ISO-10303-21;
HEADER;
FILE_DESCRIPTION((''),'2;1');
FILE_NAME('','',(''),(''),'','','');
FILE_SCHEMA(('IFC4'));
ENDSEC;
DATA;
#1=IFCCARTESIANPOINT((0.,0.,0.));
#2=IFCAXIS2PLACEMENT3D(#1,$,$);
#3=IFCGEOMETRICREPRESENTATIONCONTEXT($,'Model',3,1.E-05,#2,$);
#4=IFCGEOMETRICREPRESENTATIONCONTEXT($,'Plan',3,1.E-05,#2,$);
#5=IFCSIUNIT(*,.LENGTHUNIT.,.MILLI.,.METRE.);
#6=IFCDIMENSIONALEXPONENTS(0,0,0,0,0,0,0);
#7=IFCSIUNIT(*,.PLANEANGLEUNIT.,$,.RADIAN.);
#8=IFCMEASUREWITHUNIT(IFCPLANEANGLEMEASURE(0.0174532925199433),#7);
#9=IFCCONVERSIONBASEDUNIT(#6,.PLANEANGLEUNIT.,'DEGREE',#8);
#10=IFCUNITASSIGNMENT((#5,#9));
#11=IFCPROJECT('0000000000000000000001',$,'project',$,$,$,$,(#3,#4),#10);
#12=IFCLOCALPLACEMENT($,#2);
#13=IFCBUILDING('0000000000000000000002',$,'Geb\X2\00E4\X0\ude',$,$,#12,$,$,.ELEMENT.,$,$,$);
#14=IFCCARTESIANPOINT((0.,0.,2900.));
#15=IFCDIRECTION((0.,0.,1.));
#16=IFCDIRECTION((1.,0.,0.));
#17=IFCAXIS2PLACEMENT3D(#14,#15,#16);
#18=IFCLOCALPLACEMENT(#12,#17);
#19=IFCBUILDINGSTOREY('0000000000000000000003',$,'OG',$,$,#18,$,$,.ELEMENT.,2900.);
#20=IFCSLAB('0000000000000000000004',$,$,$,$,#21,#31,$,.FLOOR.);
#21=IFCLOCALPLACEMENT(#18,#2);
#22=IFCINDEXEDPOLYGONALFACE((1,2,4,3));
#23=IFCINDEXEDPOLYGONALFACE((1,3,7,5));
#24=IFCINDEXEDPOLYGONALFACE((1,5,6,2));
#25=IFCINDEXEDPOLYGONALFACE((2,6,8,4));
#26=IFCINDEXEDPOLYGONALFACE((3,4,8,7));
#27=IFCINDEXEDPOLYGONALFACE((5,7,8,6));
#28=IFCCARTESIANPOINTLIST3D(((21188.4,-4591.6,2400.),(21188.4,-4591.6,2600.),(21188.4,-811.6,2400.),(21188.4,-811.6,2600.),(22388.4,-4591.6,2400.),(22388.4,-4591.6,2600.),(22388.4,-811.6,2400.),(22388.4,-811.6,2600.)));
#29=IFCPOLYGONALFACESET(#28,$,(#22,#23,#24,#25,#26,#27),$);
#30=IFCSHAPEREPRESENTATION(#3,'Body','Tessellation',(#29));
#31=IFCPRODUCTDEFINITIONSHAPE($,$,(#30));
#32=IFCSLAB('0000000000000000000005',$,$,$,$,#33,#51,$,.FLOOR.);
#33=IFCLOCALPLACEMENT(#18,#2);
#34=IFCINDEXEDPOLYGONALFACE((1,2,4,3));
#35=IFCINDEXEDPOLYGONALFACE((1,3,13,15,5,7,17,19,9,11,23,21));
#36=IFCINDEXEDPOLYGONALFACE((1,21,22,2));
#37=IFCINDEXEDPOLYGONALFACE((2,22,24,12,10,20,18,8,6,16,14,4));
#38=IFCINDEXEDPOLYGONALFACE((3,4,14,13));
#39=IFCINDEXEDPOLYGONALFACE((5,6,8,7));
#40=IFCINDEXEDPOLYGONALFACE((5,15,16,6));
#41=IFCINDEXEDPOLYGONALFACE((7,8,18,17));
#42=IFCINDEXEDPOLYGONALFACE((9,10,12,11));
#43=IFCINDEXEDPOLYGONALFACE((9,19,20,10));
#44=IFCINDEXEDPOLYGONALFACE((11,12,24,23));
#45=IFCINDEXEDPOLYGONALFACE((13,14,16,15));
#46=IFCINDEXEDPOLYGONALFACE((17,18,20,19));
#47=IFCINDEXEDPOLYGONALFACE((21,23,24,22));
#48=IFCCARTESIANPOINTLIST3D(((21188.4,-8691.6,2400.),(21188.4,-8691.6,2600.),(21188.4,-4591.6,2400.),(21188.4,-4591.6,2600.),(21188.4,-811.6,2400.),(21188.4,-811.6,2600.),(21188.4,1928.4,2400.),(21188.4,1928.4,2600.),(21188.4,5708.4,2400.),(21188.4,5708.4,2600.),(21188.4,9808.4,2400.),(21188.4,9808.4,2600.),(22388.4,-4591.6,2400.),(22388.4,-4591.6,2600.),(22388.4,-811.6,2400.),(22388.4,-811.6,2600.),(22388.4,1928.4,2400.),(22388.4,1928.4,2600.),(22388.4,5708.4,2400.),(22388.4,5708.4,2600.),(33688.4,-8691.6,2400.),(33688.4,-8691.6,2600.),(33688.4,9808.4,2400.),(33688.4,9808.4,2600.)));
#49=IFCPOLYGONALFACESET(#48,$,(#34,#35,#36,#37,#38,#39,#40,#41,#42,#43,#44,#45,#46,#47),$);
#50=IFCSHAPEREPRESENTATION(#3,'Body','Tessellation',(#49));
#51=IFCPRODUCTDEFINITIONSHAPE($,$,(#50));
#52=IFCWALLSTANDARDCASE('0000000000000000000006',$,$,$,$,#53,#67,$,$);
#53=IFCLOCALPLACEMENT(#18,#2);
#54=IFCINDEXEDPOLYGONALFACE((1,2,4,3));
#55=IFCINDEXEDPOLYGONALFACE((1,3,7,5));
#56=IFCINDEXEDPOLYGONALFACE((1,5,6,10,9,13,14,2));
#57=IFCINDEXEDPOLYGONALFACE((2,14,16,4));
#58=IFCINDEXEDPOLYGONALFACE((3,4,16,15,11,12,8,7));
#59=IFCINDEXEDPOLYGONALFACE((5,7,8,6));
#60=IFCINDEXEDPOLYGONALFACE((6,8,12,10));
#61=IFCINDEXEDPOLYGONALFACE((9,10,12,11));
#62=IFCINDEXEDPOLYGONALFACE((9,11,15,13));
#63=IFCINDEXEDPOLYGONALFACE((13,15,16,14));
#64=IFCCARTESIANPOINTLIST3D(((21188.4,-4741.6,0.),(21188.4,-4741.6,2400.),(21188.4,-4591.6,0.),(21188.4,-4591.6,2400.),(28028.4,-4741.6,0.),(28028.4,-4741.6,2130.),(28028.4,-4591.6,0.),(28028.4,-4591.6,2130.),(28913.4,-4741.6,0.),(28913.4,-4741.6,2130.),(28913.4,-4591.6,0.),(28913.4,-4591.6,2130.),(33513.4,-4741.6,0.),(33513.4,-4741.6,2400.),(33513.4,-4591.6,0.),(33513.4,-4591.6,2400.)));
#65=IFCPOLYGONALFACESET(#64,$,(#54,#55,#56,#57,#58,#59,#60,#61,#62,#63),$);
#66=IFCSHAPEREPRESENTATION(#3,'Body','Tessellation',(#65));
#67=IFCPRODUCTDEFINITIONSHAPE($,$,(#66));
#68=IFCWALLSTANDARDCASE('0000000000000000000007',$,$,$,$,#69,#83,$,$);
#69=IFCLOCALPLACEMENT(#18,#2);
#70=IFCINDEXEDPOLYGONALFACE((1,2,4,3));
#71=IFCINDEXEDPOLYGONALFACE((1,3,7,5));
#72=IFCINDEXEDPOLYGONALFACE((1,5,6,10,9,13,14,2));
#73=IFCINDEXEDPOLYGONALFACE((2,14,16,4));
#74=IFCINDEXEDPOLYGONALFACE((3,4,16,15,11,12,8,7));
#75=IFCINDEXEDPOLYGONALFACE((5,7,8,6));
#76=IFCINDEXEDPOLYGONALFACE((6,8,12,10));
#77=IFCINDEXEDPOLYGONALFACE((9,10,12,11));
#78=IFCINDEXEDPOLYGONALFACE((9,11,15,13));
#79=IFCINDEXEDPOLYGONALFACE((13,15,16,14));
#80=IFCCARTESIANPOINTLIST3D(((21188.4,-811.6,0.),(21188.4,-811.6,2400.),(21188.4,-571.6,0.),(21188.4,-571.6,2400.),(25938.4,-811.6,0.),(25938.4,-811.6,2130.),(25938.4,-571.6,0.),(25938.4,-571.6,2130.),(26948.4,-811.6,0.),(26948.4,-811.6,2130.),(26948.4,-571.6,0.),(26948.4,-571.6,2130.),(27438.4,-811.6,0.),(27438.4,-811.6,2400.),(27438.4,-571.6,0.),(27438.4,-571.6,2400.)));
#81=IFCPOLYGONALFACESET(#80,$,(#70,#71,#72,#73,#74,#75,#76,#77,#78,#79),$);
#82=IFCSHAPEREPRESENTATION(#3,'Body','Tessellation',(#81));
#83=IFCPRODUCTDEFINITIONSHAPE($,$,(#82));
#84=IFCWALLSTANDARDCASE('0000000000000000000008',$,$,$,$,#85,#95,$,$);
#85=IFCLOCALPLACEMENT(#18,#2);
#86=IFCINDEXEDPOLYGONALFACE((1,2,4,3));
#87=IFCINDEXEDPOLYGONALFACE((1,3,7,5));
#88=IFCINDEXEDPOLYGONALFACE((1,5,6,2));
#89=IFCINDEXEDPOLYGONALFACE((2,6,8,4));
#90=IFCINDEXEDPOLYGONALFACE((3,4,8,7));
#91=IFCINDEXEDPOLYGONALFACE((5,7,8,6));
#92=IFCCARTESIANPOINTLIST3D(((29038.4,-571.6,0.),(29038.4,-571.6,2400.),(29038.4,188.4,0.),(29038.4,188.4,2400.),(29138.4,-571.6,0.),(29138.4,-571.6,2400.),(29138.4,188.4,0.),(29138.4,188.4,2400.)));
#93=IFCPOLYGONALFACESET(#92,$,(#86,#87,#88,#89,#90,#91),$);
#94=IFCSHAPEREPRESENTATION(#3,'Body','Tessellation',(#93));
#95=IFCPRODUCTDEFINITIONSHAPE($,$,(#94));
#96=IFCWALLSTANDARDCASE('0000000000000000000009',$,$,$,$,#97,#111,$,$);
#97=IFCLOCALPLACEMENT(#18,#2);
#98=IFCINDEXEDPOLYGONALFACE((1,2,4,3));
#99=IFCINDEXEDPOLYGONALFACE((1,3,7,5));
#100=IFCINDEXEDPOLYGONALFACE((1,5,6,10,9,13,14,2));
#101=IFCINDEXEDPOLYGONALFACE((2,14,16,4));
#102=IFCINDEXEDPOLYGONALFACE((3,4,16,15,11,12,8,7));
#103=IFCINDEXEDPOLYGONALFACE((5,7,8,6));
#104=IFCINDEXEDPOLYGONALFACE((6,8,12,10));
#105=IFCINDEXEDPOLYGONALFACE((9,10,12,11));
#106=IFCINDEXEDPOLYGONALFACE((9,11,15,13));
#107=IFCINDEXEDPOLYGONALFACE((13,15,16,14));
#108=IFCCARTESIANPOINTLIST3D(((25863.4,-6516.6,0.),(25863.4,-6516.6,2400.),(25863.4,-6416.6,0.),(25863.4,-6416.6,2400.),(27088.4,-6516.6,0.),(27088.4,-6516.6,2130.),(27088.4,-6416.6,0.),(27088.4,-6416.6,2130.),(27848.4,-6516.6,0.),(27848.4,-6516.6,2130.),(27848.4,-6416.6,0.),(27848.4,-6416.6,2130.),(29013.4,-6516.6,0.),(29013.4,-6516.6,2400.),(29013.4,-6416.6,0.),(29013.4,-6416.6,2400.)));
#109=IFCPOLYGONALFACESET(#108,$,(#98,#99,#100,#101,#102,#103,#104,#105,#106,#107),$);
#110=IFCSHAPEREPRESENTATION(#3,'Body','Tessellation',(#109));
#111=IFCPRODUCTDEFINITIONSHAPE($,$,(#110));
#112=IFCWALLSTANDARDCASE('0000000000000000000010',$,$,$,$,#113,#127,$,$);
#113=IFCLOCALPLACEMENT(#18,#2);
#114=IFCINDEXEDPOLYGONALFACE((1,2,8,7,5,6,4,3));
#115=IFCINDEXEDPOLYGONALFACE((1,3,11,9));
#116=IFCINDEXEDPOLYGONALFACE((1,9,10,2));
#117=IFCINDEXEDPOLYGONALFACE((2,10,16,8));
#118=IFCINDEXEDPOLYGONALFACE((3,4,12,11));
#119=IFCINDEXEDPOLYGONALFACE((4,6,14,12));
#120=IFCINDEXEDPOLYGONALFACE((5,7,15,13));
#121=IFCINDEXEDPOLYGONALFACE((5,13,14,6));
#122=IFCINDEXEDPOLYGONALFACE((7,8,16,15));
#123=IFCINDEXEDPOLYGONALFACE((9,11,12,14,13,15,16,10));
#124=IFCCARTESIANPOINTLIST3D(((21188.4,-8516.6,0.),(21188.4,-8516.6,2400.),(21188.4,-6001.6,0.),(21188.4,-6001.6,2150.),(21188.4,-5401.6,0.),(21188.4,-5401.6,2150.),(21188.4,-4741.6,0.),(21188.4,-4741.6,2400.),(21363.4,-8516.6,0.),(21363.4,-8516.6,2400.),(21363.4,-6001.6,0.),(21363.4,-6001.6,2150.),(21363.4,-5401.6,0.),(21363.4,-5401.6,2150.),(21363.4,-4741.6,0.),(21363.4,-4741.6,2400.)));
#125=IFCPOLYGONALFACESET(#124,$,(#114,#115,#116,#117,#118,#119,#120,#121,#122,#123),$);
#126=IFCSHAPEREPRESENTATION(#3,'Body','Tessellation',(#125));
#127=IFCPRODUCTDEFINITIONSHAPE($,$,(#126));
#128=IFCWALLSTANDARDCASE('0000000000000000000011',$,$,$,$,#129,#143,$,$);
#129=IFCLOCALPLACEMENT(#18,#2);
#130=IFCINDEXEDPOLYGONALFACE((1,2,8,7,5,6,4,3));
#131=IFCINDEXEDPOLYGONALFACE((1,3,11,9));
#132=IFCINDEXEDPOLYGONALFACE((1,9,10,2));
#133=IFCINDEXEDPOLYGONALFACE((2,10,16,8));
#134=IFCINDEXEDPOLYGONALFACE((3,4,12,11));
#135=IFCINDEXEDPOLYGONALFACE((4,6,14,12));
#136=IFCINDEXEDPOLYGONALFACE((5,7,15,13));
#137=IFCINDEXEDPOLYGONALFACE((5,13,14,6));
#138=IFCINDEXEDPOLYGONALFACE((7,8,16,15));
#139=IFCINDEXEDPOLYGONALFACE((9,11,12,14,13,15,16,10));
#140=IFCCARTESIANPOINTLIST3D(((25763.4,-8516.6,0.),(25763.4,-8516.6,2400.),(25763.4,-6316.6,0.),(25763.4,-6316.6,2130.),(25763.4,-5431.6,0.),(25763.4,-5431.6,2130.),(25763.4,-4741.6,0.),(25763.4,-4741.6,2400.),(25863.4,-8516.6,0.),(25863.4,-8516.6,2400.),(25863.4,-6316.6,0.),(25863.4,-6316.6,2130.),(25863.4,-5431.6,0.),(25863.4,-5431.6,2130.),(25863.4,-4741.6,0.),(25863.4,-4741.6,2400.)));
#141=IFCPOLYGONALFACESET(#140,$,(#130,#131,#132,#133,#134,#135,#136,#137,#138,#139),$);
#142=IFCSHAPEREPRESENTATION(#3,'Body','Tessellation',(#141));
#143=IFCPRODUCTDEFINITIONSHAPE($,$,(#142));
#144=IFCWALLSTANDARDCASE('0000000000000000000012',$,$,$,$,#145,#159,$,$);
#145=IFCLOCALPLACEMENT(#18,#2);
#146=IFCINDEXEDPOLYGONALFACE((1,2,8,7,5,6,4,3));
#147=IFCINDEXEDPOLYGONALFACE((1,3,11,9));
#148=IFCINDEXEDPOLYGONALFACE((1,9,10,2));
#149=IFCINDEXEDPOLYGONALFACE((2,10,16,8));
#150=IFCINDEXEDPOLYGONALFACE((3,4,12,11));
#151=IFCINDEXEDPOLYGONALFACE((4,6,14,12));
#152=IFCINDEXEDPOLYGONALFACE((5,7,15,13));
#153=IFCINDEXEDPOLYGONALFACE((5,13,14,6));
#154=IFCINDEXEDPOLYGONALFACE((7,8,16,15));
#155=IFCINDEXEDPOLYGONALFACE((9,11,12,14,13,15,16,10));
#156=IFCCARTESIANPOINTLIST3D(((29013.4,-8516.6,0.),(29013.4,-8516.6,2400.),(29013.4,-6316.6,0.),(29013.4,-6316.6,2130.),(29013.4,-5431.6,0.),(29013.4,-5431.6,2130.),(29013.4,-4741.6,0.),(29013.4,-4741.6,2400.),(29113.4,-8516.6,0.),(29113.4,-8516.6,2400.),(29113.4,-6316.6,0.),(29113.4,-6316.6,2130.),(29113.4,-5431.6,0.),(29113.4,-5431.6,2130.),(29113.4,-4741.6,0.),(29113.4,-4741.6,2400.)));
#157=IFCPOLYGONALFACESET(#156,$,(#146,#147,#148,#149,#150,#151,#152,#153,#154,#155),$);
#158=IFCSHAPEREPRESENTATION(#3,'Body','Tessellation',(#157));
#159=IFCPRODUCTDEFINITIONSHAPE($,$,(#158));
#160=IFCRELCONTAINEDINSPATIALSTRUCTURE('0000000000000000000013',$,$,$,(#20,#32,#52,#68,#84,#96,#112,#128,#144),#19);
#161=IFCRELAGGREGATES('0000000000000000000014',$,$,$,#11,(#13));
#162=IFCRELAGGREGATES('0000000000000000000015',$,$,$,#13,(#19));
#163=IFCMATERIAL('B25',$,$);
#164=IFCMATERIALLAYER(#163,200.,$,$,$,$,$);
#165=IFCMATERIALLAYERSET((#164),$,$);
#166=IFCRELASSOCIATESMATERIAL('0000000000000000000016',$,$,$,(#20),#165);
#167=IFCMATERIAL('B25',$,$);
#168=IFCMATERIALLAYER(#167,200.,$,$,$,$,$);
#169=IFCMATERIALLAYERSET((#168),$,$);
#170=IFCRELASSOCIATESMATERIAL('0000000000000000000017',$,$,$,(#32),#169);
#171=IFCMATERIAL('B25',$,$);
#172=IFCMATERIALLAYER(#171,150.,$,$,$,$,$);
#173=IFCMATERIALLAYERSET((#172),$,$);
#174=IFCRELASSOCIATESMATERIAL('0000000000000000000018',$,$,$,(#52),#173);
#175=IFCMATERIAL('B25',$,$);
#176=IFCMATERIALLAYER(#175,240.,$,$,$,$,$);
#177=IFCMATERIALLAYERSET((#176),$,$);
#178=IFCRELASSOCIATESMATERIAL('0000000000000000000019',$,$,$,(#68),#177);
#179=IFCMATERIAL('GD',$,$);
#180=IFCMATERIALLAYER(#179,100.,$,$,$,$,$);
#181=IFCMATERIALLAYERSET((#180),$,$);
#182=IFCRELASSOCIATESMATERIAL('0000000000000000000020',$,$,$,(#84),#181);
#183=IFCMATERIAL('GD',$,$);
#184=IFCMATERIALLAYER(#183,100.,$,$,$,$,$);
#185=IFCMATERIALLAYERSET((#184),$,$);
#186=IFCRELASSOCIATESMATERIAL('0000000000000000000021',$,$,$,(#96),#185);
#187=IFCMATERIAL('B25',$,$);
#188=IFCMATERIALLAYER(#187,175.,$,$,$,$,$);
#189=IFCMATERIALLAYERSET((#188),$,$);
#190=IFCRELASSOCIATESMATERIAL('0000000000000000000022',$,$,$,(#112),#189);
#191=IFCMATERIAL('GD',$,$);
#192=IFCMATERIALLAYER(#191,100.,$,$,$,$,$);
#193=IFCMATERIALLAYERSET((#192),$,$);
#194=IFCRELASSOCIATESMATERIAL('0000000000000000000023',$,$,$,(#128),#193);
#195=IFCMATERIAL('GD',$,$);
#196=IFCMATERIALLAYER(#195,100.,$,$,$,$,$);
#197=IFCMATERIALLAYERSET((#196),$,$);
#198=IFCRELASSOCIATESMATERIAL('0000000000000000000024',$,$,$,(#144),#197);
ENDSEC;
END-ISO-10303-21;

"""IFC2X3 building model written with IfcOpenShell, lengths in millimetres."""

from ifc_helpers import new_model, entity, si_unit, converted_unit, frame, frame_2d, origin, origin_with_axes, place, context, project, spatial, polyline, rectangle, outline, extrude, material, layer, layer_set, layer_usage, element, save


model = new_model("IFC2X3")

# Units and contexts
model_context = context("Model", 3, precision=1e-05, world=origin())
plan_context = context("Plan", 3, precision=1e-05, world=origin())
ifc_project = project(units=[si_unit("LENGTHUNIT", "METRE", prefix="MILLI"), converted_unit("PLANEANGLEUNIT", "DEGREE", entity("IfcPlaneAngleMeasure", 0.0174532925199433), si_unit("PLANEANGLEUNIT", "RADIAN"), dimensions=[0, 0, 0, 0, 0, 0, 0])], contexts=[model_context, plan_context])

# Building, storey
building_placement = place(None, origin())
building = spatial("IfcBuilding", under=ifc_project, at=building_placement, Name="Gebäude", CompositionType="ELEMENT")
storey_placement = place(building_placement, frame((0.0, 0.0, 2900.0), z_axis=(0.0, 0.0, 1.0), x_axis=(1.0, 0.0, 0.0)))
storey = spatial("IfcBuildingStorey", under=building, at=storey_placement, Name="OG", CompositionType="ELEMENT", Elevation=2900.0)

# Slabs
ifc_material_1 = material(Name="B25")
ifc_layer_1 = layer(ifc_material_1, 200.0)
ifc_layer_set_1 = layer_set([ifc_layer_1])
ifc_layer_usage_1 = layer_usage(ifc_layer_set_1, "AXIS3", "POSITIVE", 0.0)
slab_1_placement = place(storey_placement, frame((21188.4, -811.6, 2400.0), z_axis=(0.0, 0.0, 1.0), x_axis=(1.0, 0.0, 0.0)))
element("IfcSlab", 1, at=slab_1_placement, inside=storey, material=ifc_layer_usage_1, PredefinedType="FLOOR", context=model_context, shape_type="SweptSolid", body=[
    extrude(rectangle(XDim=3780.0, YDim=1200.0, at=frame_2d((600.0, -1890.0), x_axis=(0.0, -1.0))), origin_with_axes(), (0.0, 0.0, 1.0), 200.0),
])
ifc_material_2 = material(Name="B25")
ifc_layer_2 = layer(ifc_material_2, 200.0)
ifc_layer_set_2 = layer_set([ifc_layer_2])
ifc_layer_usage_2 = layer_usage(ifc_layer_set_2, "AXIS3", "POSITIVE", 0.0)
slab_2_placement = place(storey_placement, frame((21188.4, -8691.6, 2400.0), z_axis=(0.0, 0.0, 1.0), x_axis=(1.0, 0.0, 0.0)))
element("IfcSlab", 2, at=slab_2_placement, inside=storey, material=ifc_layer_usage_2, PredefinedType="FLOOR", context=model_context, shape_type="SweptSolid", body=[
    extrude(outline(polyline([(0.0, 18500.0), (0.0, 14400.0), (1200.0, 14400.0), (1200.0, 10620.0), (0.0, 10620.0), (0.0, 7880.0), (1200.0, 7880.0), (1200.0, 4100.0), (0.0, 4100.0), (0.0, 0.0), (12500.0, 0.0), (12500.0, 18500.0), (0.0, 18500.0)])), origin_with_axes(), (0.0, 0.0, 1.0), 200.0),
])

# Walls, openings
ifc_material_3 = material(Name="B25")
ifc_layer_3 = layer(ifc_material_3, 150.0)
ifc_layer_set_3 = layer_set([ifc_layer_3])
ifc_layer_usage_3 = layer_usage(ifc_layer_set_3, "AXIS2", "POSITIVE", 0.0)
wall_1_placement = place(storey_placement, frame((21188.4, -4741.6, 0.0), z_axis=(0.0, 0.0, 1.0), x_axis=(1.0, 0.0, 0.0)))
wall_1 = element("IfcWallStandardCase", 3, at=wall_1_placement, inside=storey, material=ifc_layer_usage_3, context=model_context, shape_type="SweptSolid", body=[
    extrude(rectangle(XDim=12325.0, YDim=150.0, at=frame_2d((6162.5, 75.0), x_axis=(1.0, 0.0))), origin_with_axes(), (0.0, 0.0, 1.0), 2400.0),
])
opening_1_placement = place(wall_1_placement, frame((6840.0, 0.0, 0.0), z_axis=(0.0, 1.0, 0.0), x_axis=(0.0, 0.0, 1.0)))
element("IfcOpeningElement", 4, at=opening_1_placement, cuts=wall_1, ObjectType="Opening", context=model_context, shape_type="SweptSolid", body=[
    extrude(rectangle(XDim=2130.0, YDim=885.0, at=frame_2d((1065.0, 442.5), x_axis=(1.0, 0.0))), origin_with_axes(), (0.0, 0.0, 1.0), 150.0),
])
ifc_material_4 = material(Name="B25")
ifc_layer_4 = layer(ifc_material_4, 240.0)
ifc_layer_set_4 = layer_set([ifc_layer_4])
ifc_layer_usage_4 = layer_usage(ifc_layer_set_4, "AXIS2", "POSITIVE", 0.0)
wall_2_placement = place(storey_placement, frame((27438.4, -571.6, 0.0), z_axis=(0.0, 0.0, 1.0), x_axis=(-1.0, 0.0, 0.0)))
wall_2 = element("IfcWallStandardCase", 5, at=wall_2_placement, inside=storey, material=ifc_layer_usage_4, context=model_context, shape_type="SweptSolid", body=[
    extrude(rectangle(XDim=6250.0, YDim=240.0, at=frame_2d((3125.0, 120.0), x_axis=(1.0, 0.0))), origin_with_axes(), (0.0, 0.0, 1.0), 2400.0),
])
opening_2_placement = place(wall_2_placement, frame((490.0, 0.0, 0.0), z_axis=(0.0, 1.0, 0.0), x_axis=(0.0, 0.0, 1.0)))
element("IfcOpeningElement", 6, at=opening_2_placement, cuts=wall_2, ObjectType="Opening", context=model_context, shape_type="SweptSolid", body=[
    extrude(rectangle(XDim=2130.0, YDim=1010.0, at=frame_2d((1065.0, 505.0), x_axis=(1.0, 0.0))), origin_with_axes(), (0.0, 0.0, 1.0), 240.0),
])

# Wall
ifc_material_5 = material(Name="GD")
ifc_layer_5 = layer(ifc_material_5, 100.0)
ifc_layer_set_5 = layer_set([ifc_layer_5])
ifc_layer_usage_5 = layer_usage(ifc_layer_set_5, "AXIS2", "POSITIVE", 0.0)
wall_3_placement = place(storey_placement, frame((29138.4, -571.6, 0.0), z_axis=(0.0, 0.0, 1.0), x_axis=(0.0, 1.0, 0.0)))
element("IfcWallStandardCase", 7, at=wall_3_placement, inside=storey, material=ifc_layer_usage_5, context=model_context, shape_type="SweptSolid", body=[
    extrude(rectangle(XDim=760.0, YDim=100.0, at=frame_2d((380.0, 50.0), x_axis=(1.0, 0.0))), origin_with_axes(), (0.0, 0.0, 1.0), 2400.0),
])

# Walls, openings
ifc_material_6 = material(Name="GD")
ifc_layer_6 = layer(ifc_material_6, 100.0)
ifc_layer_set_6 = layer_set([ifc_layer_6])
ifc_layer_usage_6 = layer_usage(ifc_layer_set_6, "AXIS2", "POSITIVE", 0.0)
wall_4_placement = place(storey_placement, frame((25863.4, -6516.6, 0.0), z_axis=(0.0, 0.0, 1.0), x_axis=(1.0, 0.0, 0.0)))
wall_4 = element("IfcWallStandardCase", 8, at=wall_4_placement, inside=storey, material=ifc_layer_usage_6, context=model_context, shape_type="SweptSolid", body=[
    extrude(rectangle(XDim=3150.0, YDim=100.0, at=frame_2d((1575.0, 50.0), x_axis=(1.0, 0.0))), origin_with_axes(), (0.0, 0.0, 1.0), 2400.0),
])
opening_3_placement = place(wall_4_placement, frame((1225.0, 0.0, 0.0), z_axis=(0.0, 1.0, 0.0), x_axis=(0.0, 0.0, 1.0)))
element("IfcOpeningElement", 9, at=opening_3_placement, cuts=wall_4, ObjectType="Opening", context=model_context, shape_type="SweptSolid", body=[
    extrude(rectangle(XDim=2130.0, YDim=760.0, at=frame_2d((1065.0, 380.0), x_axis=(1.0, 0.0))), origin_with_axes(), (0.0, 0.0, 1.0), 100.0),
])
ifc_material_7 = material(Name="B25")
ifc_layer_7 = layer(ifc_material_7, 175.0)
ifc_layer_set_7 = layer_set([ifc_layer_7])
ifc_layer_usage_7 = layer_usage(ifc_layer_set_7, "AXIS2", "POSITIVE", 0.0)
wall_5_placement = place(storey_placement, frame((21188.4, -4741.6, 0.0), z_axis=(0.0, 0.0, 1.0), x_axis=(0.0, -1.0, 0.0)))
wall_5 = element("IfcWallStandardCase", 10, at=wall_5_placement, inside=storey, material=ifc_layer_usage_7, context=model_context, shape_type="SweptSolid", body=[
    extrude(rectangle(XDim=3775.0, YDim=175.0, at=frame_2d((1887.5, 87.5), x_axis=(1.0, 0.0))), origin_with_axes(), (0.0, 0.0, 1.0), 2400.0),
])
opening_4_placement = place(wall_5_placement, frame((660.0, 0.0, 0.0), z_axis=(0.0, 1.0, 0.0), x_axis=(0.0, 0.0, 1.0)))
element("IfcOpeningElement", 11, at=opening_4_placement, cuts=wall_5, ObjectType="Opening", context=model_context, shape_type="SweptSolid", body=[
    extrude(rectangle(XDim=2150.0, YDim=600.0, at=frame_2d((1075.0, 300.0), x_axis=(1.0, 0.0))), origin_with_axes(), (0.0, 0.0, 1.0), 175.0),
])
ifc_material_8 = material(Name="GD")
ifc_layer_8 = layer(ifc_material_8, 100.0)
ifc_layer_set_8 = layer_set([ifc_layer_8])
ifc_layer_usage_8 = layer_usage(ifc_layer_set_8, "AXIS2", "POSITIVE", 0.0)
wall_6_placement = place(storey_placement, frame((25763.4, -4741.6, 0.0), z_axis=(0.0, 0.0, 1.0), x_axis=(0.0, -1.0, 0.0)))
wall_6 = element("IfcWallStandardCase", 12, at=wall_6_placement, inside=storey, material=ifc_layer_usage_8, context=model_context, shape_type="SweptSolid", body=[
    extrude(rectangle(XDim=3775.0, YDim=100.0, at=frame_2d((1887.5, 50.0), x_axis=(1.0, 0.0))), origin_with_axes(), (0.0, 0.0, 1.0), 2400.0),
])
opening_5_placement = place(wall_6_placement, frame((690.0, 0.0, 0.0), z_axis=(0.0, 1.0, 0.0), x_axis=(0.0, 0.0, 1.0)))
element("IfcOpeningElement", 13, at=opening_5_placement, cuts=wall_6, ObjectType="Opening", context=model_context, shape_type="SweptSolid", body=[
    extrude(rectangle(XDim=2130.0, YDim=885.0, at=frame_2d((1065.0, 442.5), x_axis=(1.0, 0.0))), origin_with_axes(), (0.0, 0.0, 1.0), 100.0),
])
ifc_material_9 = material(Name="GD")
ifc_layer_9 = layer(ifc_material_9, 100.0)
ifc_layer_set_9 = layer_set([ifc_layer_9])
ifc_layer_usage_9 = layer_usage(ifc_layer_set_9, "AXIS2", "POSITIVE", 0.0)
wall_7_placement = place(storey_placement, frame((29113.4, -8516.6, 0.0), z_axis=(0.0, 0.0, 1.0), x_axis=(0.0, 1.0, 0.0)))
wall_7 = element("IfcWallStandardCase", 14, at=wall_7_placement, inside=storey, material=ifc_layer_usage_9, context=model_context, shape_type="SweptSolid", body=[
    extrude(rectangle(XDim=3775.0, YDim=100.0, at=frame_2d((1887.5, 50.0), x_axis=(1.0, 0.0))), origin_with_axes(), (0.0, 0.0, 1.0), 2400.0),
])
opening_6_placement = place(wall_7_placement, frame((2200.0, 0.0, 0.0), z_axis=(0.0, 1.0, 0.0), x_axis=(0.0, 0.0, 1.0)))
element("IfcOpeningElement", 15, at=opening_6_placement, cuts=wall_7, ObjectType="Opening", context=model_context, shape_type="SweptSolid", body=[
    extrude(rectangle(XDim=2130.0, YDim=885.0, at=frame_2d((1065.0, 442.5), x_axis=(1.0, 0.0))), origin_with_axes(), (0.0, 0.0, 1.0), 100.0),
])

save(model, "model.ifc")
